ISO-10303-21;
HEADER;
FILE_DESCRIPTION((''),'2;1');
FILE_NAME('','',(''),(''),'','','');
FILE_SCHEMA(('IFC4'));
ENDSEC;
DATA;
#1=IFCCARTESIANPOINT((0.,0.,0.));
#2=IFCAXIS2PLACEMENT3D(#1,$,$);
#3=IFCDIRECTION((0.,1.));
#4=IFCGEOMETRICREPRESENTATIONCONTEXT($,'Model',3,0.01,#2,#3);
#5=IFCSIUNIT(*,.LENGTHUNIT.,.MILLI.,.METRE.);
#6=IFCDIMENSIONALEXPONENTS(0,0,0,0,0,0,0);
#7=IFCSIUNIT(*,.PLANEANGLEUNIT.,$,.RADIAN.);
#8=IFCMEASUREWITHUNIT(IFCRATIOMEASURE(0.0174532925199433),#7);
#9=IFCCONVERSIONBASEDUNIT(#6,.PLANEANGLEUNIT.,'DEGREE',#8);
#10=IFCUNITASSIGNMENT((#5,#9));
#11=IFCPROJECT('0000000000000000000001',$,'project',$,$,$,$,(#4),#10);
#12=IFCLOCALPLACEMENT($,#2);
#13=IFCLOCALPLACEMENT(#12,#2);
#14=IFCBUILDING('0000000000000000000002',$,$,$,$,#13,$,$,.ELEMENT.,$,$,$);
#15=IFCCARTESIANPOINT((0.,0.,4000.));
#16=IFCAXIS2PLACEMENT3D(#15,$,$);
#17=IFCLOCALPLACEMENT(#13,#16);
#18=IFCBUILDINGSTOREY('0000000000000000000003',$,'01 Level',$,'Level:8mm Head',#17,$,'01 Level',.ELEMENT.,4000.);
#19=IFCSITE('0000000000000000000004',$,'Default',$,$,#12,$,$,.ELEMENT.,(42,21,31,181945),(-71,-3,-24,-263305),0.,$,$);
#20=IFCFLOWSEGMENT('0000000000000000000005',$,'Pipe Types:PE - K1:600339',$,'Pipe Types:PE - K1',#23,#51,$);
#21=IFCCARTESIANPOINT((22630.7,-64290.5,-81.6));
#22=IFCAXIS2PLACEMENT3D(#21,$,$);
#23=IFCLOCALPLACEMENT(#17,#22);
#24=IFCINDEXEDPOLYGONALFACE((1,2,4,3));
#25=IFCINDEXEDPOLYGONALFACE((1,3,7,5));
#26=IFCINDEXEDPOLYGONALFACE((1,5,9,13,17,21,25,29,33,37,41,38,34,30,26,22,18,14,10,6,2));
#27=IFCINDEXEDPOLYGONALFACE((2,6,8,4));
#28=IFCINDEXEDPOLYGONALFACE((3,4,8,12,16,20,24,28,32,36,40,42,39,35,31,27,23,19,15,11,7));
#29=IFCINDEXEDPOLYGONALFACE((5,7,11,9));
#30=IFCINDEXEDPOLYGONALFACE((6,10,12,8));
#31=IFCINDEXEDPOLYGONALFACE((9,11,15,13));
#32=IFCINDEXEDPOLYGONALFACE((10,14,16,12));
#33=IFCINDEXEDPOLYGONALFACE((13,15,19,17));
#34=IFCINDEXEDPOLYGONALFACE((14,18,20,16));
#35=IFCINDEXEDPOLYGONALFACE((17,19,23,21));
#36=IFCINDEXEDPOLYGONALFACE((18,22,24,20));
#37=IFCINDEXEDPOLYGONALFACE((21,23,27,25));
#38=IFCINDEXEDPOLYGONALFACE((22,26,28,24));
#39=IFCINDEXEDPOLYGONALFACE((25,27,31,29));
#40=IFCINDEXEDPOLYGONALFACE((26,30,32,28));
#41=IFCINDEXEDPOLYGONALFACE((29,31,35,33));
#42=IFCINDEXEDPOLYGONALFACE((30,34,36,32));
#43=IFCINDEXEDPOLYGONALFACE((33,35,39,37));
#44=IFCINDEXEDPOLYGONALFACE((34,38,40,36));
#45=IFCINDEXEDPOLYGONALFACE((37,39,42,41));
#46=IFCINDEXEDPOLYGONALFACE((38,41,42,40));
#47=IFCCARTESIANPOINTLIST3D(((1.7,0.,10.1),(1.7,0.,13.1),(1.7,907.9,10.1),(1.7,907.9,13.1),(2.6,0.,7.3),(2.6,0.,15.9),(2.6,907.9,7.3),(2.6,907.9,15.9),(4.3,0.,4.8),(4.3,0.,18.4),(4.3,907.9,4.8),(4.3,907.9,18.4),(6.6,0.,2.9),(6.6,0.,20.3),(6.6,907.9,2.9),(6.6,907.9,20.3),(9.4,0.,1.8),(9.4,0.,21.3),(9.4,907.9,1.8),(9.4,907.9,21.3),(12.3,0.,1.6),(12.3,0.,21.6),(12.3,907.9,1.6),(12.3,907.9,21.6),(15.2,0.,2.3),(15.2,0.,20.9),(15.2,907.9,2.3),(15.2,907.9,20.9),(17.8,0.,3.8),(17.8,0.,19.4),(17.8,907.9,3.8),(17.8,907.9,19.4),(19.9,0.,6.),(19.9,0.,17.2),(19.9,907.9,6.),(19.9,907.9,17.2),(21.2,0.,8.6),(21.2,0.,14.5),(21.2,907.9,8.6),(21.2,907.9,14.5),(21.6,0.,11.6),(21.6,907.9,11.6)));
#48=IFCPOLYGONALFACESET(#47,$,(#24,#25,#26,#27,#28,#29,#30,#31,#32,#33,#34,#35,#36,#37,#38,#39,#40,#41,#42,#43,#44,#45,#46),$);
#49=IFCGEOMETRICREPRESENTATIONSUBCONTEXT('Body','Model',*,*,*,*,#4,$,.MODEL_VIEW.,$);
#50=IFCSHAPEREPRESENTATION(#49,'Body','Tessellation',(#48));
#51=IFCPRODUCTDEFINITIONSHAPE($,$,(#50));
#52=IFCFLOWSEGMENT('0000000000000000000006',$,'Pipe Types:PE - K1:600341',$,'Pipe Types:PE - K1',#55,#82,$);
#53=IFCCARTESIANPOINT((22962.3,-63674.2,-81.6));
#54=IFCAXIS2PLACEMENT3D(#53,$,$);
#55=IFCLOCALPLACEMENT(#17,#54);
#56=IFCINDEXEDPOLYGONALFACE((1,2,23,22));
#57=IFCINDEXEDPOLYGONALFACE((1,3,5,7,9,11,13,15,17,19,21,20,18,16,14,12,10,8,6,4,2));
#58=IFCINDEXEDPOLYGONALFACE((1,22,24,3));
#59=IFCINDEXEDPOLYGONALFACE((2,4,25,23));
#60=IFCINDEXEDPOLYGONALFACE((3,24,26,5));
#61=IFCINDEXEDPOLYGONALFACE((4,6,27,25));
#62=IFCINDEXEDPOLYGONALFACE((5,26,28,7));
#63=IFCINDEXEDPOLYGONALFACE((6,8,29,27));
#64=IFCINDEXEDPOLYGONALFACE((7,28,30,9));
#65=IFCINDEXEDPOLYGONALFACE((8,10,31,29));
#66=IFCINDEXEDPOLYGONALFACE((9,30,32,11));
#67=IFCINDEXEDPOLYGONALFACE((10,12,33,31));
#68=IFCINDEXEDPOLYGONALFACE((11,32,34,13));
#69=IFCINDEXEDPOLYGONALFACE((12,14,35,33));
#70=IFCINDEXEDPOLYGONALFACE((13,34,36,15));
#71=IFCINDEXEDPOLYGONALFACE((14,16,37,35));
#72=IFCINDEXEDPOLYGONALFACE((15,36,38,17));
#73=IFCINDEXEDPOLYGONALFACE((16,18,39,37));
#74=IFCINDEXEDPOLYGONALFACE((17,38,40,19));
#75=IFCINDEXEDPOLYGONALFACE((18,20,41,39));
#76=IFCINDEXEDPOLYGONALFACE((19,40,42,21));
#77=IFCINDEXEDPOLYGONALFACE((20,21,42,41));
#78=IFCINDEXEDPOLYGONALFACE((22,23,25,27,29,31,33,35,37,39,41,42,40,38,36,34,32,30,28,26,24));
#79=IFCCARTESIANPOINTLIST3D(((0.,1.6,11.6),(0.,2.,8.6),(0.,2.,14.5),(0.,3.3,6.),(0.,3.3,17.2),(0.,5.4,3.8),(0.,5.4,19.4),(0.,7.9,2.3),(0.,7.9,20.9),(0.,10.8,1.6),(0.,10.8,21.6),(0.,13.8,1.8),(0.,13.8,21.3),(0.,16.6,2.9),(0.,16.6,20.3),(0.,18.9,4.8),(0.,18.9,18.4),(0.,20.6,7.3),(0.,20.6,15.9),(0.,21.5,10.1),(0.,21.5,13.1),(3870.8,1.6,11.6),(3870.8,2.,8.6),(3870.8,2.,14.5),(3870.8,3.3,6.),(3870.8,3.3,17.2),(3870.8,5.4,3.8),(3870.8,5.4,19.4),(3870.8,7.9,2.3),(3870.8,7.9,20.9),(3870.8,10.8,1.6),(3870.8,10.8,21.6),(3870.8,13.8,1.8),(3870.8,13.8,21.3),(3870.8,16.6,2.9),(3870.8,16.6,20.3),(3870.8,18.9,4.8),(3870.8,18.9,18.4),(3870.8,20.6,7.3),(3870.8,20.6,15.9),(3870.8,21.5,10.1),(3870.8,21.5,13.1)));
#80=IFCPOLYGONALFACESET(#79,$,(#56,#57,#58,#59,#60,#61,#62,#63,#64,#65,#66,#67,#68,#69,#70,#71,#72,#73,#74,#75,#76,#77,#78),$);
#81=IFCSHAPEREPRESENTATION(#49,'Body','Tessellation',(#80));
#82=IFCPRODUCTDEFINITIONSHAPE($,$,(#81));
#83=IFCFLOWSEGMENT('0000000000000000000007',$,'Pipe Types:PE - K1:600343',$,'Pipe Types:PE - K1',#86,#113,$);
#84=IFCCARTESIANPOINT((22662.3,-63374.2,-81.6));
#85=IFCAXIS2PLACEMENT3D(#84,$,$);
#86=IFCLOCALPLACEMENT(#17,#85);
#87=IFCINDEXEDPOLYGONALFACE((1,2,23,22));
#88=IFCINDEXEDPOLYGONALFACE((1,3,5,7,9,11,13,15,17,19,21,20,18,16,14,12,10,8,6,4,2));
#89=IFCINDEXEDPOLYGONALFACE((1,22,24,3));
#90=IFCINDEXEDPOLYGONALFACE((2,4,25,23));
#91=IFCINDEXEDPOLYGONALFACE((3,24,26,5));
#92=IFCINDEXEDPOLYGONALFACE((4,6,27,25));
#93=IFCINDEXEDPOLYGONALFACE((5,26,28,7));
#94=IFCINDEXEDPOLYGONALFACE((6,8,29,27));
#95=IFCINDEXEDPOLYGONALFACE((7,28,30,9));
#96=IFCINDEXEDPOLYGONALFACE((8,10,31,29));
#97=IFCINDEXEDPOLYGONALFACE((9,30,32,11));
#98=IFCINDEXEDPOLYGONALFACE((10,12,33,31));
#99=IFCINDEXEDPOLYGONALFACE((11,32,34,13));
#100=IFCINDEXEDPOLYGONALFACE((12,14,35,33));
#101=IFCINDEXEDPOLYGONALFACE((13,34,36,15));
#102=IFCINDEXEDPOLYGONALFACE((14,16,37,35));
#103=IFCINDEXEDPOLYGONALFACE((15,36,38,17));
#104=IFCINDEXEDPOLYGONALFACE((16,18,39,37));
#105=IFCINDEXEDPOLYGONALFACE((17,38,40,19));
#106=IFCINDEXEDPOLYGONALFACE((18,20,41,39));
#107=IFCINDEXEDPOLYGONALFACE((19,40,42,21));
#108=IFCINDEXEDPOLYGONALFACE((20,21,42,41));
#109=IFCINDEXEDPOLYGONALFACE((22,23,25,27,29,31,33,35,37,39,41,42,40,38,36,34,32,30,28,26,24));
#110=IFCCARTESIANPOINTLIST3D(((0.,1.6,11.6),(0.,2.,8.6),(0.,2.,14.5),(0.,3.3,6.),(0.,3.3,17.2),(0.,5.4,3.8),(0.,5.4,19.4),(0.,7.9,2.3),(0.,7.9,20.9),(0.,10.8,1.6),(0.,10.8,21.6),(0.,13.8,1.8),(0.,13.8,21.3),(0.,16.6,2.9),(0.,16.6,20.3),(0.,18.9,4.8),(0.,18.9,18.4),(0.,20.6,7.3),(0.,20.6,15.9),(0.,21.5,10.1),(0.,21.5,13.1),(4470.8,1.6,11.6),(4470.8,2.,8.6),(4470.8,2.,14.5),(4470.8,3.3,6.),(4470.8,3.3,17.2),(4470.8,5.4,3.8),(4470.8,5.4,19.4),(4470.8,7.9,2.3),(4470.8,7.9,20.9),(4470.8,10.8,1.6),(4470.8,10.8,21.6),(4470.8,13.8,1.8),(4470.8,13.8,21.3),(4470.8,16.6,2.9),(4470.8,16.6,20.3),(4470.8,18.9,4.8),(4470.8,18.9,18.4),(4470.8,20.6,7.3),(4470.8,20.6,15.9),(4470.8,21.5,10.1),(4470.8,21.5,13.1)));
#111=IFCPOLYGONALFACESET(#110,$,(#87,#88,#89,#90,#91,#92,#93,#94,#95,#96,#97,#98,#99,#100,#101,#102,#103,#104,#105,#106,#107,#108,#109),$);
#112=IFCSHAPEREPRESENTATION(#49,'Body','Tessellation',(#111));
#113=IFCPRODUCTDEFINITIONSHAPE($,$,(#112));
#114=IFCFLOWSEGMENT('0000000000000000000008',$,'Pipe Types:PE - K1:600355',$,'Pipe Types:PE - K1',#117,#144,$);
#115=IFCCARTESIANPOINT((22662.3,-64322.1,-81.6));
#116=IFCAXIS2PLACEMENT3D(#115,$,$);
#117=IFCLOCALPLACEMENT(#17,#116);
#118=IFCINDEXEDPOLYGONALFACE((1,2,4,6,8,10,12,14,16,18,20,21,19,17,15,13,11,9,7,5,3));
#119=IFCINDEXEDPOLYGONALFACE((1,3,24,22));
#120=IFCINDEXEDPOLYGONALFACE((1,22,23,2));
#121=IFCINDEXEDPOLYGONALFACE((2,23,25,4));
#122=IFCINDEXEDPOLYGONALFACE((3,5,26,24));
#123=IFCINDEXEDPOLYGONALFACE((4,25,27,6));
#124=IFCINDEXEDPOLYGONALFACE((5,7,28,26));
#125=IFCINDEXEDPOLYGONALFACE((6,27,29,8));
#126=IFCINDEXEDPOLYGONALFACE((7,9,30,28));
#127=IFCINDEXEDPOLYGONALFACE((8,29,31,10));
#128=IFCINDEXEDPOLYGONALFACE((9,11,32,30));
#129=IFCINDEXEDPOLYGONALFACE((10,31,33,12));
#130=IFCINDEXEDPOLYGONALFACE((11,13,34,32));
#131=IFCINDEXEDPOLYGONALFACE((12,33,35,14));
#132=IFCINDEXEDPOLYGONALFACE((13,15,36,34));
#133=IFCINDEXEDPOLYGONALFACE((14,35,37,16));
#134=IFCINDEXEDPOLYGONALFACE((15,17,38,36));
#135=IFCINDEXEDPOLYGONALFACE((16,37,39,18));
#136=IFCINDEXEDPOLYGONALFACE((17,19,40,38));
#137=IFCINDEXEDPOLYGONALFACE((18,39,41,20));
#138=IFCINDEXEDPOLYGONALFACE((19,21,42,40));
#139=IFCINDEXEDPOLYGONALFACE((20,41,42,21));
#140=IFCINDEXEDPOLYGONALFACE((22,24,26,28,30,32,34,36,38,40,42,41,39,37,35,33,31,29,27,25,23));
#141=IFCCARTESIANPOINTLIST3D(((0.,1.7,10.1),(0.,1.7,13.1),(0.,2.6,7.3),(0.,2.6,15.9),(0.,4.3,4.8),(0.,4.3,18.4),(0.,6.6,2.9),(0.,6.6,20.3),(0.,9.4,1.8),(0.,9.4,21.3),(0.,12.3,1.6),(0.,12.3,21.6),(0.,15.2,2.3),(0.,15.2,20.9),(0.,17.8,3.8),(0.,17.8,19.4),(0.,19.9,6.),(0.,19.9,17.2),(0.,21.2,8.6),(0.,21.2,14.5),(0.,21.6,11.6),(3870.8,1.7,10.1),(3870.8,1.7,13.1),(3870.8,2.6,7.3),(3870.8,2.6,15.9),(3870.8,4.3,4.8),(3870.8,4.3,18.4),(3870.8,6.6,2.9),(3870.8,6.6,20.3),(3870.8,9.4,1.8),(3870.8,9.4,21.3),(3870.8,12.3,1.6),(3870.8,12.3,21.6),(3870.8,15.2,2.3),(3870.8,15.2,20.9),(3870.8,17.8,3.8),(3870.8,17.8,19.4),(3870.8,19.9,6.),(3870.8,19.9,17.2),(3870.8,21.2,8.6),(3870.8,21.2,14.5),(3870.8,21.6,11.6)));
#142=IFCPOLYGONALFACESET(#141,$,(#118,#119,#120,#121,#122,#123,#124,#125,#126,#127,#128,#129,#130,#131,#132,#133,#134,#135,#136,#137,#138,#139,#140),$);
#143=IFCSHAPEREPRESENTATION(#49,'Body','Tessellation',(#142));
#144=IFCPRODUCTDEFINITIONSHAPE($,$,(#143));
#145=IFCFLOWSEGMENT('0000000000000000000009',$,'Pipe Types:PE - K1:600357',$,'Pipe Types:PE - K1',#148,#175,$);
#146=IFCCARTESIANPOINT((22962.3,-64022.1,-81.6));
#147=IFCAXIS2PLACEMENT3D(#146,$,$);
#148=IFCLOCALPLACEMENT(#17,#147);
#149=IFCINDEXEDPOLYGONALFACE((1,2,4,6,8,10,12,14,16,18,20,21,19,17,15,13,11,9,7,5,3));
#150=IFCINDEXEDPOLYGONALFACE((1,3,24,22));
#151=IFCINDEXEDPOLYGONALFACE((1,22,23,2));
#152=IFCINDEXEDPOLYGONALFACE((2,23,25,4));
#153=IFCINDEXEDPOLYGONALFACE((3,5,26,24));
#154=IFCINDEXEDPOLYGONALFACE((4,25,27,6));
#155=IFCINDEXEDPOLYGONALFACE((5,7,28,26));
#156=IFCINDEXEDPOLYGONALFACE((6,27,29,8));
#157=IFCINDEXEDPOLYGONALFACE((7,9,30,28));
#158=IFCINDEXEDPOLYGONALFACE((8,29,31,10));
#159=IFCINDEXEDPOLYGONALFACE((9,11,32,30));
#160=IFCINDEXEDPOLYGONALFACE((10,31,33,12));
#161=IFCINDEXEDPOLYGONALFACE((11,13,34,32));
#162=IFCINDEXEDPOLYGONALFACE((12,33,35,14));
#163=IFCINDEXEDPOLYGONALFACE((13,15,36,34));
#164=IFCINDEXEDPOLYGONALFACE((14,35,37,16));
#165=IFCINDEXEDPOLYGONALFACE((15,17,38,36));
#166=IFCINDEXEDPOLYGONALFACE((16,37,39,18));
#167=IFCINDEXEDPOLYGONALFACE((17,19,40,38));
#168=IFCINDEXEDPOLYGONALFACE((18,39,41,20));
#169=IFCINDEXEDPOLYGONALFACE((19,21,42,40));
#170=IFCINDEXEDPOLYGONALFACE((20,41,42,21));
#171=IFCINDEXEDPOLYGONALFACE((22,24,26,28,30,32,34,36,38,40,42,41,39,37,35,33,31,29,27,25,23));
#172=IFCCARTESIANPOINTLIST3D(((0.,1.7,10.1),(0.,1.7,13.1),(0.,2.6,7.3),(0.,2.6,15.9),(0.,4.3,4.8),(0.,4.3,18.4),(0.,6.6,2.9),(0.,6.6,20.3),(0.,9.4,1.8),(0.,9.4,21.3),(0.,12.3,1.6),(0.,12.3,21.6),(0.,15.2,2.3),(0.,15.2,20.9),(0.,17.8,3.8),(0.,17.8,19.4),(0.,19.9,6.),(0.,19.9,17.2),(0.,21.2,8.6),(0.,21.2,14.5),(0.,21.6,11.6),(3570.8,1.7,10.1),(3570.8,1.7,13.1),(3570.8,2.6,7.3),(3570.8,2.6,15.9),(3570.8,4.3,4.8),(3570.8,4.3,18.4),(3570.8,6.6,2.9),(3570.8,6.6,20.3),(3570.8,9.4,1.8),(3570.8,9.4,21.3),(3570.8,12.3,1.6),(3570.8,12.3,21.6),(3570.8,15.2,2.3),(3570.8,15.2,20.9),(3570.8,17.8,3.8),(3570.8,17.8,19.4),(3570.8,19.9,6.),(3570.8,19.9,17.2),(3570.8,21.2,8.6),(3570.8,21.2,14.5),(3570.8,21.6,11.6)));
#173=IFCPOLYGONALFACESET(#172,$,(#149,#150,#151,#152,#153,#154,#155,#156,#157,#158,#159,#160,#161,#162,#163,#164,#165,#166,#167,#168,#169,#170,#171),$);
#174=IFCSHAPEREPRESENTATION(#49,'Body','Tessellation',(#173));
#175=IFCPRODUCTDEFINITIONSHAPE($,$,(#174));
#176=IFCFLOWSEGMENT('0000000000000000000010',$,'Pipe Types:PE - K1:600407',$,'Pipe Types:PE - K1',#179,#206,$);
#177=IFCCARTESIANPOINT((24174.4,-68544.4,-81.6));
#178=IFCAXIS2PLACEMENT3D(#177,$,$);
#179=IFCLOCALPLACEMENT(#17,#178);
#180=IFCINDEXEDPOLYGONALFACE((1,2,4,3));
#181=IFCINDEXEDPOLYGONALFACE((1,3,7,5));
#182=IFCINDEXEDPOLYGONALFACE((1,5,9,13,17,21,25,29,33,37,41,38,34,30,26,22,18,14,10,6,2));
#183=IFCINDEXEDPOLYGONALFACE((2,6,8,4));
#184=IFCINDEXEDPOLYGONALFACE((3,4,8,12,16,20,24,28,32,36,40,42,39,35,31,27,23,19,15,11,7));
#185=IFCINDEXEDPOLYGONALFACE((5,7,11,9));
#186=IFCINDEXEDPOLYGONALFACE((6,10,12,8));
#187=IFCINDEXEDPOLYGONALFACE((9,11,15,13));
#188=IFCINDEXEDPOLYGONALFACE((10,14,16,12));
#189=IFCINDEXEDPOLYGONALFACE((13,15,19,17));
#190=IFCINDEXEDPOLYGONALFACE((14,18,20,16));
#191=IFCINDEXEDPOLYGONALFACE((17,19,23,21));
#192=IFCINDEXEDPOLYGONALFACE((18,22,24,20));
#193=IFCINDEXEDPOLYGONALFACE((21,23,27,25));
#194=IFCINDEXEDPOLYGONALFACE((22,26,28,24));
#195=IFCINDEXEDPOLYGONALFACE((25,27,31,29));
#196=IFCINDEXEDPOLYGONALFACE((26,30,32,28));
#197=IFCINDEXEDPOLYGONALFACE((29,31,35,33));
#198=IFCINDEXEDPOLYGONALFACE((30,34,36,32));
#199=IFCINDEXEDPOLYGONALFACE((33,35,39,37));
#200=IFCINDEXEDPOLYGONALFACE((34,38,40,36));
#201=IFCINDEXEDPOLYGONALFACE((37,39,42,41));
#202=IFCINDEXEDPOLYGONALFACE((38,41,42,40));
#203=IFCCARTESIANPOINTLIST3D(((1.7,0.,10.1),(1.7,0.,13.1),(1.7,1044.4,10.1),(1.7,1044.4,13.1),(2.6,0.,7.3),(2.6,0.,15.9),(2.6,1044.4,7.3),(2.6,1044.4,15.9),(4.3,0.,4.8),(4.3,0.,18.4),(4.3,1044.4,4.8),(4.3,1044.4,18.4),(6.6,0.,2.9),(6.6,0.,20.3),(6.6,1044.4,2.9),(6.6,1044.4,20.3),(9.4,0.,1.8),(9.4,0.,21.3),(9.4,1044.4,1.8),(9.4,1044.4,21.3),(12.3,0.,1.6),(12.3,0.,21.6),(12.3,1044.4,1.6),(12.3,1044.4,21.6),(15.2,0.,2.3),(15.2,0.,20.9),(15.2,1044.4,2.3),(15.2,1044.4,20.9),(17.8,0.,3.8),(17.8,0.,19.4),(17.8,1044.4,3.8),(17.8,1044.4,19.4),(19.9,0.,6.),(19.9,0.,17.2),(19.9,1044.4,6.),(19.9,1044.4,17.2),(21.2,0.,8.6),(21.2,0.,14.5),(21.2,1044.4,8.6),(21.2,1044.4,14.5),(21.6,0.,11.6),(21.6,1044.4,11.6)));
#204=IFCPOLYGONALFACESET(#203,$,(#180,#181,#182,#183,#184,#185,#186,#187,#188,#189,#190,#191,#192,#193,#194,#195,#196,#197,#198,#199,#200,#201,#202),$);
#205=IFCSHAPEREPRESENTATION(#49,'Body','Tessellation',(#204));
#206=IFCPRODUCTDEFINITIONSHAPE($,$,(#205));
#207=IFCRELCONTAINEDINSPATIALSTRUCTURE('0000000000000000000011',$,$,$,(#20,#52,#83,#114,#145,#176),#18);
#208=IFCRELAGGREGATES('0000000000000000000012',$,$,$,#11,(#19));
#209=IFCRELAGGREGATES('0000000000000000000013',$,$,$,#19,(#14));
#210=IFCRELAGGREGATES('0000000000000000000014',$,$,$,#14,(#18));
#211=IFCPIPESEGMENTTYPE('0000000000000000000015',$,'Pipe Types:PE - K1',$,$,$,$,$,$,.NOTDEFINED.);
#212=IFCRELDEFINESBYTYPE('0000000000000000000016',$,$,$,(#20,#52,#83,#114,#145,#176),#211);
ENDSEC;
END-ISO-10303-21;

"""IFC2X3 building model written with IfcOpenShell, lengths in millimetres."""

from ifc_helpers import new_model, entity, si_unit, converted_unit, direction, frame, frame_2d, origin, origin_2d_with_axis, place, context, subcontext, project, spatial, circle, extrude, type_object, element, save


model = new_model("IFC2X3")

# Units and contexts
model_context = context("Model", 3, precision=0.01, world=origin(), true_north=direction((0.0, 1.0)))
body_context = subcontext(model_context, "Body", "Model", "MODEL_VIEW")
ifc_project = project(units=[si_unit("LENGTHUNIT", "METRE", prefix="MILLI"), converted_unit("PLANEANGLEUNIT", "DEGREE", entity("IfcRatioMeasure", 0.0174532925199433), si_unit("PLANEANGLEUNIT", "RADIAN"), dimensions=[0, 0, 0, 0, 0, 0, 0])], contexts=[model_context])

# Site, building, storey
site_placement = place(None, origin())
site = spatial("IfcSite", under=ifc_project, at=site_placement, Name="Default", CompositionType="ELEMENT", RefLatitude=(42, 21, 31, 181945), RefLongitude=(-71, -3, -24, -263305), RefElevation=0.0)
building_placement = place(site_placement, origin())
building = spatial("IfcBuilding", under=site, at=building_placement, CompositionType="ELEMENT")
storey_placement = place(building_placement, frame((0.0, 0.0, 4000.0)))
storey = spatial("IfcBuildingStorey", under=building, at=storey_placement, Name="01 Level", ObjectType="Level:8mm Head", LongName="01 Level", CompositionType="ELEMENT", Elevation=4000.0)

# Flow segments
pipe_segment_type = type_object("IfcPipeSegmentType", Name="Pipe Types:PE - K1", PredefinedType="NOTDEFINED")
flow_segment_1_placement = place(storey_placement, frame((22630.7, -64290.5, -81.6)))
element("IfcFlowSegment", 1, at=flow_segment_1_placement, inside=storey, type_object=pipe_segment_type, Name="Pipe Types:PE - K1:600339", ObjectType="Pipe Types:PE - K1", context=body_context, shape_type="SweptSolid", body=[
    extrude(circle(Radius=10.0, at=origin_2d_with_axis()), frame((11.6, 0.0, 11.6), z_axis=(0.0, 1.0, 0.0), x_axis=(1.0, 0.0, 0.0)), (0.0, 0.0, 1.0), 907.9),
])
flow_segment_2_placement = place(storey_placement, frame((22962.3, -63674.2, -81.6)))
element("IfcFlowSegment", 2, at=flow_segment_2_placement, inside=storey, type_object=pipe_segment_type, Name="Pipe Types:PE - K1:600341", ObjectType="Pipe Types:PE - K1", context=body_context, shape_type="SweptSolid", body=[
    extrude(circle(Radius=10.0, at=origin_2d_with_axis()), frame((0.0, 11.6, 11.6), z_axis=(1.0, 0.0, 0.0), x_axis=(0.0, -1.0, 0.0)), (0.0, 0.0, 1.0), 3870.8),
])
flow_segment_3_placement = place(storey_placement, frame((22662.3, -63374.2, -81.6)))
element("IfcFlowSegment", 3, at=flow_segment_3_placement, inside=storey, type_object=pipe_segment_type, Name="Pipe Types:PE - K1:600343", ObjectType="Pipe Types:PE - K1", context=body_context, shape_type="SweptSolid", body=[
    extrude(circle(Radius=10.0, at=origin_2d_with_axis()), frame((0.0, 11.6, 11.6), z_axis=(1.0, 0.0, 0.0), x_axis=(0.0, -1.0, 0.0)), (0.0, 0.0, 1.0), 4470.8),
])
flow_segment_4_placement = place(storey_placement, frame((22662.3, -64322.1, -81.6)))
element("IfcFlowSegment", 4, at=flow_segment_4_placement, inside=storey, type_object=pipe_segment_type, Name="Pipe Types:PE - K1:600355", ObjectType="Pipe Types:PE - K1", context=body_context, shape_type="SweptSolid", body=[
    extrude(circle(Radius=10.0, at=frame_2d((0.0, 0.0), x_axis=(1.0, 0.0))), frame((0.0, 11.6, 11.6), z_axis=(1.0, 0.0, 0.0), x_axis=(0.0, 1.0, 0.0)), (0.0, 0.0, 1.0), 3870.8),
])
flow_segment_5_placement = place(storey_placement, frame((22962.3, -64022.1, -81.6)))
element("IfcFlowSegment", 5, at=flow_segment_5_placement, inside=storey, type_object=pipe_segment_type, Name="Pipe Types:PE - K1:600357", ObjectType="Pipe Types:PE - K1", context=body_context, shape_type="SweptSolid", body=[
    extrude(circle(Radius=10.0, at=frame_2d((0.0, 0.0), x_axis=(1.0, 0.0))), frame((0.0, 11.6, 11.6), z_axis=(1.0, 0.0, 0.0), x_axis=(0.0, 1.0, 0.0)), (0.0, 0.0, 1.0), 3570.8),
])
flow_segment_6_placement = place(storey_placement, frame((24174.4, -68544.4, -81.6)))
element("IfcFlowSegment", 6, at=flow_segment_6_placement, inside=storey, type_object=pipe_segment_type, Name="Pipe Types:PE - K1:600407", ObjectType="Pipe Types:PE - K1", context=body_context, shape_type="SweptSolid", body=[
    extrude(circle(Radius=10.0, at=origin_2d_with_axis()), frame((11.6, 0.0, 11.6), z_axis=(0.0, 1.0, 0.0), x_axis=(1.0, 0.0, 0.0)), (0.0, 0.0, 1.0), 1044.4),
])

save(model, "model.ifc")
